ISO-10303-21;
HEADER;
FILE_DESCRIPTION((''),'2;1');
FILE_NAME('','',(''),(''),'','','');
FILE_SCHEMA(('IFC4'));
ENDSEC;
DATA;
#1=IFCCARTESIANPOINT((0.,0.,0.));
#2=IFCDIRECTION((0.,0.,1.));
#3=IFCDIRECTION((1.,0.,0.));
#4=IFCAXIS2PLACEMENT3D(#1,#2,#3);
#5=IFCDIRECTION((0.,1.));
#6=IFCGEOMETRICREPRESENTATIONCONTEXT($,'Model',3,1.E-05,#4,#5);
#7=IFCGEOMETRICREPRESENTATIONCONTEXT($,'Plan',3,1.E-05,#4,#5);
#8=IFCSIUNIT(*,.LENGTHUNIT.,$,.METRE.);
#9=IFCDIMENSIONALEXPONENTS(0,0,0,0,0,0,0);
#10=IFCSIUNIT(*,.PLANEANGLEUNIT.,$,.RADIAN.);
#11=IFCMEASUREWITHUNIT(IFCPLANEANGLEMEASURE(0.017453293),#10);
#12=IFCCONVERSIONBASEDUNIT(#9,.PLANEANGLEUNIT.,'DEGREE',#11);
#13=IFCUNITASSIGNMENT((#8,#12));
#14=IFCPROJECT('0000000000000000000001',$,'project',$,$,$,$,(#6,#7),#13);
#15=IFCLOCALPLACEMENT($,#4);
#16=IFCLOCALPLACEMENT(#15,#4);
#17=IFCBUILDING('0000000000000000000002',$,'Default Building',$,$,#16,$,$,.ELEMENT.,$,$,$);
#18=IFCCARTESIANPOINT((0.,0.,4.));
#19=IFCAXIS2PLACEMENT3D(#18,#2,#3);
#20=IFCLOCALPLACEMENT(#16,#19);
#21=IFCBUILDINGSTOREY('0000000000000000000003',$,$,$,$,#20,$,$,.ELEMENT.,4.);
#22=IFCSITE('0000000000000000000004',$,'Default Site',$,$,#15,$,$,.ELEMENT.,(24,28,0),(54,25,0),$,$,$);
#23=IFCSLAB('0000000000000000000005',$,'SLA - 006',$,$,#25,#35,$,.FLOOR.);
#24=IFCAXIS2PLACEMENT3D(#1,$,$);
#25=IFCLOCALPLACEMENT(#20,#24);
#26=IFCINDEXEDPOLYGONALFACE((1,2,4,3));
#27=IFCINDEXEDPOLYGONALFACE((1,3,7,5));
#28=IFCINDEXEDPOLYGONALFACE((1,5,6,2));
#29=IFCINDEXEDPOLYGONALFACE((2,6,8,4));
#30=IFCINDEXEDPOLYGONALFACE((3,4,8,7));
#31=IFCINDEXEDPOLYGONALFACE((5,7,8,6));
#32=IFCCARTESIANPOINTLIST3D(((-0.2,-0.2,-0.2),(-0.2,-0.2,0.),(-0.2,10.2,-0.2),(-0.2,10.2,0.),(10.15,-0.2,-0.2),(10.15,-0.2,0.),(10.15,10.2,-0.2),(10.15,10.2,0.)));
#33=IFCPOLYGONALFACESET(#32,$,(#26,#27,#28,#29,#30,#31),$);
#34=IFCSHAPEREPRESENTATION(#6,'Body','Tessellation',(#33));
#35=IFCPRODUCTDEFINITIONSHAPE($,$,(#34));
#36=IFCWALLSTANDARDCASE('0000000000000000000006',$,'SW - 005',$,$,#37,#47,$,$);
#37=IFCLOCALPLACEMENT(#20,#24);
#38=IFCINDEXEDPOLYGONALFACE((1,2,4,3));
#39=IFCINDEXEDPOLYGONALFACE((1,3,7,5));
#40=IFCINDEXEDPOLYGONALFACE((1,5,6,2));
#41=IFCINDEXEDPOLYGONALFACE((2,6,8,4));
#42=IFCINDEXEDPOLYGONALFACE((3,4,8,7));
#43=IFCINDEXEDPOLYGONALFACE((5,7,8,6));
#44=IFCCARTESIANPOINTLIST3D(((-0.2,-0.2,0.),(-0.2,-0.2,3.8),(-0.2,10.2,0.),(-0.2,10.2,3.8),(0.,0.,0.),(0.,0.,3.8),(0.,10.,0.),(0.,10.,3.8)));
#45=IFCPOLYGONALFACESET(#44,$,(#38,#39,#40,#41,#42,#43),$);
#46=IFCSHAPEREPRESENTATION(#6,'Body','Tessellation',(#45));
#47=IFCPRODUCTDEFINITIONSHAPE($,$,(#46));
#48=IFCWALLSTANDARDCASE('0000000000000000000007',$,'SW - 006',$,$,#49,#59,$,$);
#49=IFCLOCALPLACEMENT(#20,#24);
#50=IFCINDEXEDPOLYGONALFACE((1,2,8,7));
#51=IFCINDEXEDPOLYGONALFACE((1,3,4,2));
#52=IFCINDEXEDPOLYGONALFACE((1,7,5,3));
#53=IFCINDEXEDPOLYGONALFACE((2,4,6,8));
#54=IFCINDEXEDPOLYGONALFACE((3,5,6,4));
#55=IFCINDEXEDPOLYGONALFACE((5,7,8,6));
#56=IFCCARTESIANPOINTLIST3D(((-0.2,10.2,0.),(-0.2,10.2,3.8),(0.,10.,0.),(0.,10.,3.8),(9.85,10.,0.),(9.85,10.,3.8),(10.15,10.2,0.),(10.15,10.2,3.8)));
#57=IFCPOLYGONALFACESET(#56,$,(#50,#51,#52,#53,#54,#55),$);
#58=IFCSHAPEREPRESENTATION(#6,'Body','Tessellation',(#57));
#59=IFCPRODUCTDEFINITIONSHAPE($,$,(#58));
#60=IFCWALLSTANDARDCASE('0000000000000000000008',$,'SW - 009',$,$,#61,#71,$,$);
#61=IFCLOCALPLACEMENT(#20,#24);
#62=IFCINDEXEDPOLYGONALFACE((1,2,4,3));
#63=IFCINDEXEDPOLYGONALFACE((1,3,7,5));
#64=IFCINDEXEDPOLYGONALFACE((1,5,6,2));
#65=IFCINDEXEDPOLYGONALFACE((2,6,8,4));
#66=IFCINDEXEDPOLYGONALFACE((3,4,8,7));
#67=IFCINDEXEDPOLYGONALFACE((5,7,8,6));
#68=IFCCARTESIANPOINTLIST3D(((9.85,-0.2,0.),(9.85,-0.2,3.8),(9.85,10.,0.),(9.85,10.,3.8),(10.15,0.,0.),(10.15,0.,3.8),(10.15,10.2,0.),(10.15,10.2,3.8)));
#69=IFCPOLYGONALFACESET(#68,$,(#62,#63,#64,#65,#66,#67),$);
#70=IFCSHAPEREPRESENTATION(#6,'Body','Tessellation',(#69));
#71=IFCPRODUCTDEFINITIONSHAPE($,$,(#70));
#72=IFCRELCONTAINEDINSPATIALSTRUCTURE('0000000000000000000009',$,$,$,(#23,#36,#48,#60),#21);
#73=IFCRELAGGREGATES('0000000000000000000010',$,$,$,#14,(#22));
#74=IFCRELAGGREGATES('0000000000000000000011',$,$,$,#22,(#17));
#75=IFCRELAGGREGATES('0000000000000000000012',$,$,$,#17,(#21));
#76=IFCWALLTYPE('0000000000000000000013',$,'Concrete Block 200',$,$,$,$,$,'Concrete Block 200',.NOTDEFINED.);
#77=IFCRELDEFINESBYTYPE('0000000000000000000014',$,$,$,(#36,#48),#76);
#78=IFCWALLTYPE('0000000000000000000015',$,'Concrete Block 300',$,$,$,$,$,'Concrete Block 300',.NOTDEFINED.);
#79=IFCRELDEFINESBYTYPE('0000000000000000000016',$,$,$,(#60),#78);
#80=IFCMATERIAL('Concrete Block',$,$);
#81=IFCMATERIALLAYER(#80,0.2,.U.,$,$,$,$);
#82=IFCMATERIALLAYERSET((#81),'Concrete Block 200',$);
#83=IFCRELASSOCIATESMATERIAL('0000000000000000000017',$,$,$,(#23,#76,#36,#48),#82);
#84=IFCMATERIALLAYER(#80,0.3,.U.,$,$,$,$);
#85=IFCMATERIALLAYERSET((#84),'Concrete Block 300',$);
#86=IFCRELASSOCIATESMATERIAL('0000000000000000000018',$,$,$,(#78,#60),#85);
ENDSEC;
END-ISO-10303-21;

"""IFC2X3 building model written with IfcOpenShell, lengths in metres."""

from ifc_helpers import new_model, entity, si_unit, converted_unit, direction, frame, origin_with_axes, place, context, project, spatial, polyline, outline, extrude, material, layer, layer_set, layer_usage, type_object, element, save


model = new_model("IFC2X3")

# Units and contexts
model_context = context("Model", 3, precision=1e-05, world=origin_with_axes(), true_north=direction((0.0, 1.0)))
plan_context = context("Plan", 3, precision=1e-05, world=origin_with_axes(), true_north=direction((0.0, 1.0)))
ifc_project = project(units=[si_unit("LENGTHUNIT", "METRE"), converted_unit("PLANEANGLEUNIT", "DEGREE", entity("IfcPlaneAngleMeasure", 0.017453293), si_unit("PLANEANGLEUNIT", "RADIAN"), dimensions=[0, 0, 0, 0, 0, 0, 0])], contexts=[model_context, plan_context])

# Site, building, storey
site_placement = place(None, origin_with_axes())
site = spatial("IfcSite", under=ifc_project, at=site_placement, Name="Default Site", CompositionType="ELEMENT", RefLatitude=(24, 28, 0), RefLongitude=(54, 25, 0))
building_placement = place(site_placement, origin_with_axes())
building = spatial("IfcBuilding", under=site, at=building_placement, Name="Default Building", CompositionType="ELEMENT")
storey_placement = place(building_placement, frame((0.0, 0.0, 4.0), z_axis=(0.0, 0.0, 1.0), x_axis=(1.0, 0.0, 0.0)))
storey = spatial("IfcBuildingStorey", under=building, at=storey_placement, CompositionType="ELEMENT", Elevation=4.0)

# Slab
ifc_material = material(Name="Concrete Block")
ifc_layer_1 = layer(ifc_material, 0.2, ventilated="UNKNOWN")
ifc_layer_set_1 = layer_set([ifc_layer_1], Name="Concrete Block 200")
ifc_layer_usage_1 = layer_usage(ifc_layer_set_1, "AXIS3", "NEGATIVE", 0.2)
slab_placement = place(storey_placement, frame((-0.2, 10.2, -0.2), z_axis=(0.0, 0.0, 1.0), x_axis=(0.0, -1.0, 0.0)))
element("IfcSlab", 1, at=slab_placement, inside=storey, material=ifc_layer_usage_1, Name="SLA - 006", PredefinedType="FLOOR", context=model_context, shape_type="SweptSolid", body=[
    extrude(outline(polyline([(0.0, 0.0), (10.4, 0.0), (10.4, 10.35), (0.0, 10.35), (0.0, 0.0)])), origin_with_axes(), (0.0, 0.0, 1.0), 0.2),
])

# Walls
ifc_layer_usage_2 = layer_usage(ifc_layer_set_1, "AXIS2", "POSITIVE", 0.0)
wall_type_1 = type_object("IfcWallType", Name="Concrete Block 200", ElementType="Concrete Block 200", PredefinedType="NOTDEFINED", material=ifc_layer_set_1)
wall_1_placement = place(storey_placement, frame((0.0, 0.0, 0.0), z_axis=(0.0, 0.0, 1.0), x_axis=(0.0, 1.0, 0.0)))
element("IfcWallStandardCase", 2, at=wall_1_placement, inside=storey, type_object=wall_type_1, material=ifc_layer_usage_2, Name="SW - 005", context=model_context, shape_type="SweptSolid", body=[
    extrude(outline(polyline([(0.0, 0.0), (10.0, 0.0), (10.2, 0.2), (-0.2, 0.2), (0.0, 0.0)])), origin_with_axes(), (0.0, 0.0, 1.0), 3.8),
])
ifc_layer_usage_3 = layer_usage(ifc_layer_set_1, "AXIS2", "POSITIVE", 0.0)
wall_2_placement = place(storey_placement, frame((0.0, 10.0, 0.0), z_axis=(0.0, 0.0, 1.0), x_axis=(1.0, 0.0, 0.0)))
element("IfcWallStandardCase", 3, at=wall_2_placement, inside=storey, type_object=wall_type_1, material=ifc_layer_usage_3, Name="SW - 006", context=model_context, shape_type="SweptSolid", body=[
    extrude(outline(polyline([(0.0, 0.0), (9.85, 0.0), (10.15, 0.2), (-0.2, 0.2), (0.0, 0.0)])), origin_with_axes(), (0.0, 0.0, 1.0), 3.8),
])
ifc_layer_2 = layer(ifc_material, 0.3, ventilated="UNKNOWN")
ifc_layer_set_2 = layer_set([ifc_layer_2], Name="Concrete Block 300")
ifc_layer_usage_4 = layer_usage(ifc_layer_set_2, "AXIS2", "POSITIVE", 0.0)
wall_type_2 = type_object("IfcWallType", Name="Concrete Block 300", ElementType="Concrete Block 300", PredefinedType="NOTDEFINED", material=ifc_layer_set_2)
wall_3_placement = place(storey_placement, frame((10.15, 0.0, 0.0), z_axis=(0.0, 0.0, 1.0), x_axis=(0.0, 1.0, 0.0)))
element("IfcWallStandardCase", 4, at=wall_3_placement, inside=storey, type_object=wall_type_2, material=ifc_layer_usage_4, Name="SW - 009", context=model_context, shape_type="SweptSolid", body=[
    extrude(outline(polyline([(0.0, 0.0), (10.2, 0.0), (10.0, 0.3), (-0.2, 0.3), (0.0, 0.0)])), origin_with_axes(), (0.0, 0.0, 1.0), 3.8),
])

save(model, "model.ifc")
